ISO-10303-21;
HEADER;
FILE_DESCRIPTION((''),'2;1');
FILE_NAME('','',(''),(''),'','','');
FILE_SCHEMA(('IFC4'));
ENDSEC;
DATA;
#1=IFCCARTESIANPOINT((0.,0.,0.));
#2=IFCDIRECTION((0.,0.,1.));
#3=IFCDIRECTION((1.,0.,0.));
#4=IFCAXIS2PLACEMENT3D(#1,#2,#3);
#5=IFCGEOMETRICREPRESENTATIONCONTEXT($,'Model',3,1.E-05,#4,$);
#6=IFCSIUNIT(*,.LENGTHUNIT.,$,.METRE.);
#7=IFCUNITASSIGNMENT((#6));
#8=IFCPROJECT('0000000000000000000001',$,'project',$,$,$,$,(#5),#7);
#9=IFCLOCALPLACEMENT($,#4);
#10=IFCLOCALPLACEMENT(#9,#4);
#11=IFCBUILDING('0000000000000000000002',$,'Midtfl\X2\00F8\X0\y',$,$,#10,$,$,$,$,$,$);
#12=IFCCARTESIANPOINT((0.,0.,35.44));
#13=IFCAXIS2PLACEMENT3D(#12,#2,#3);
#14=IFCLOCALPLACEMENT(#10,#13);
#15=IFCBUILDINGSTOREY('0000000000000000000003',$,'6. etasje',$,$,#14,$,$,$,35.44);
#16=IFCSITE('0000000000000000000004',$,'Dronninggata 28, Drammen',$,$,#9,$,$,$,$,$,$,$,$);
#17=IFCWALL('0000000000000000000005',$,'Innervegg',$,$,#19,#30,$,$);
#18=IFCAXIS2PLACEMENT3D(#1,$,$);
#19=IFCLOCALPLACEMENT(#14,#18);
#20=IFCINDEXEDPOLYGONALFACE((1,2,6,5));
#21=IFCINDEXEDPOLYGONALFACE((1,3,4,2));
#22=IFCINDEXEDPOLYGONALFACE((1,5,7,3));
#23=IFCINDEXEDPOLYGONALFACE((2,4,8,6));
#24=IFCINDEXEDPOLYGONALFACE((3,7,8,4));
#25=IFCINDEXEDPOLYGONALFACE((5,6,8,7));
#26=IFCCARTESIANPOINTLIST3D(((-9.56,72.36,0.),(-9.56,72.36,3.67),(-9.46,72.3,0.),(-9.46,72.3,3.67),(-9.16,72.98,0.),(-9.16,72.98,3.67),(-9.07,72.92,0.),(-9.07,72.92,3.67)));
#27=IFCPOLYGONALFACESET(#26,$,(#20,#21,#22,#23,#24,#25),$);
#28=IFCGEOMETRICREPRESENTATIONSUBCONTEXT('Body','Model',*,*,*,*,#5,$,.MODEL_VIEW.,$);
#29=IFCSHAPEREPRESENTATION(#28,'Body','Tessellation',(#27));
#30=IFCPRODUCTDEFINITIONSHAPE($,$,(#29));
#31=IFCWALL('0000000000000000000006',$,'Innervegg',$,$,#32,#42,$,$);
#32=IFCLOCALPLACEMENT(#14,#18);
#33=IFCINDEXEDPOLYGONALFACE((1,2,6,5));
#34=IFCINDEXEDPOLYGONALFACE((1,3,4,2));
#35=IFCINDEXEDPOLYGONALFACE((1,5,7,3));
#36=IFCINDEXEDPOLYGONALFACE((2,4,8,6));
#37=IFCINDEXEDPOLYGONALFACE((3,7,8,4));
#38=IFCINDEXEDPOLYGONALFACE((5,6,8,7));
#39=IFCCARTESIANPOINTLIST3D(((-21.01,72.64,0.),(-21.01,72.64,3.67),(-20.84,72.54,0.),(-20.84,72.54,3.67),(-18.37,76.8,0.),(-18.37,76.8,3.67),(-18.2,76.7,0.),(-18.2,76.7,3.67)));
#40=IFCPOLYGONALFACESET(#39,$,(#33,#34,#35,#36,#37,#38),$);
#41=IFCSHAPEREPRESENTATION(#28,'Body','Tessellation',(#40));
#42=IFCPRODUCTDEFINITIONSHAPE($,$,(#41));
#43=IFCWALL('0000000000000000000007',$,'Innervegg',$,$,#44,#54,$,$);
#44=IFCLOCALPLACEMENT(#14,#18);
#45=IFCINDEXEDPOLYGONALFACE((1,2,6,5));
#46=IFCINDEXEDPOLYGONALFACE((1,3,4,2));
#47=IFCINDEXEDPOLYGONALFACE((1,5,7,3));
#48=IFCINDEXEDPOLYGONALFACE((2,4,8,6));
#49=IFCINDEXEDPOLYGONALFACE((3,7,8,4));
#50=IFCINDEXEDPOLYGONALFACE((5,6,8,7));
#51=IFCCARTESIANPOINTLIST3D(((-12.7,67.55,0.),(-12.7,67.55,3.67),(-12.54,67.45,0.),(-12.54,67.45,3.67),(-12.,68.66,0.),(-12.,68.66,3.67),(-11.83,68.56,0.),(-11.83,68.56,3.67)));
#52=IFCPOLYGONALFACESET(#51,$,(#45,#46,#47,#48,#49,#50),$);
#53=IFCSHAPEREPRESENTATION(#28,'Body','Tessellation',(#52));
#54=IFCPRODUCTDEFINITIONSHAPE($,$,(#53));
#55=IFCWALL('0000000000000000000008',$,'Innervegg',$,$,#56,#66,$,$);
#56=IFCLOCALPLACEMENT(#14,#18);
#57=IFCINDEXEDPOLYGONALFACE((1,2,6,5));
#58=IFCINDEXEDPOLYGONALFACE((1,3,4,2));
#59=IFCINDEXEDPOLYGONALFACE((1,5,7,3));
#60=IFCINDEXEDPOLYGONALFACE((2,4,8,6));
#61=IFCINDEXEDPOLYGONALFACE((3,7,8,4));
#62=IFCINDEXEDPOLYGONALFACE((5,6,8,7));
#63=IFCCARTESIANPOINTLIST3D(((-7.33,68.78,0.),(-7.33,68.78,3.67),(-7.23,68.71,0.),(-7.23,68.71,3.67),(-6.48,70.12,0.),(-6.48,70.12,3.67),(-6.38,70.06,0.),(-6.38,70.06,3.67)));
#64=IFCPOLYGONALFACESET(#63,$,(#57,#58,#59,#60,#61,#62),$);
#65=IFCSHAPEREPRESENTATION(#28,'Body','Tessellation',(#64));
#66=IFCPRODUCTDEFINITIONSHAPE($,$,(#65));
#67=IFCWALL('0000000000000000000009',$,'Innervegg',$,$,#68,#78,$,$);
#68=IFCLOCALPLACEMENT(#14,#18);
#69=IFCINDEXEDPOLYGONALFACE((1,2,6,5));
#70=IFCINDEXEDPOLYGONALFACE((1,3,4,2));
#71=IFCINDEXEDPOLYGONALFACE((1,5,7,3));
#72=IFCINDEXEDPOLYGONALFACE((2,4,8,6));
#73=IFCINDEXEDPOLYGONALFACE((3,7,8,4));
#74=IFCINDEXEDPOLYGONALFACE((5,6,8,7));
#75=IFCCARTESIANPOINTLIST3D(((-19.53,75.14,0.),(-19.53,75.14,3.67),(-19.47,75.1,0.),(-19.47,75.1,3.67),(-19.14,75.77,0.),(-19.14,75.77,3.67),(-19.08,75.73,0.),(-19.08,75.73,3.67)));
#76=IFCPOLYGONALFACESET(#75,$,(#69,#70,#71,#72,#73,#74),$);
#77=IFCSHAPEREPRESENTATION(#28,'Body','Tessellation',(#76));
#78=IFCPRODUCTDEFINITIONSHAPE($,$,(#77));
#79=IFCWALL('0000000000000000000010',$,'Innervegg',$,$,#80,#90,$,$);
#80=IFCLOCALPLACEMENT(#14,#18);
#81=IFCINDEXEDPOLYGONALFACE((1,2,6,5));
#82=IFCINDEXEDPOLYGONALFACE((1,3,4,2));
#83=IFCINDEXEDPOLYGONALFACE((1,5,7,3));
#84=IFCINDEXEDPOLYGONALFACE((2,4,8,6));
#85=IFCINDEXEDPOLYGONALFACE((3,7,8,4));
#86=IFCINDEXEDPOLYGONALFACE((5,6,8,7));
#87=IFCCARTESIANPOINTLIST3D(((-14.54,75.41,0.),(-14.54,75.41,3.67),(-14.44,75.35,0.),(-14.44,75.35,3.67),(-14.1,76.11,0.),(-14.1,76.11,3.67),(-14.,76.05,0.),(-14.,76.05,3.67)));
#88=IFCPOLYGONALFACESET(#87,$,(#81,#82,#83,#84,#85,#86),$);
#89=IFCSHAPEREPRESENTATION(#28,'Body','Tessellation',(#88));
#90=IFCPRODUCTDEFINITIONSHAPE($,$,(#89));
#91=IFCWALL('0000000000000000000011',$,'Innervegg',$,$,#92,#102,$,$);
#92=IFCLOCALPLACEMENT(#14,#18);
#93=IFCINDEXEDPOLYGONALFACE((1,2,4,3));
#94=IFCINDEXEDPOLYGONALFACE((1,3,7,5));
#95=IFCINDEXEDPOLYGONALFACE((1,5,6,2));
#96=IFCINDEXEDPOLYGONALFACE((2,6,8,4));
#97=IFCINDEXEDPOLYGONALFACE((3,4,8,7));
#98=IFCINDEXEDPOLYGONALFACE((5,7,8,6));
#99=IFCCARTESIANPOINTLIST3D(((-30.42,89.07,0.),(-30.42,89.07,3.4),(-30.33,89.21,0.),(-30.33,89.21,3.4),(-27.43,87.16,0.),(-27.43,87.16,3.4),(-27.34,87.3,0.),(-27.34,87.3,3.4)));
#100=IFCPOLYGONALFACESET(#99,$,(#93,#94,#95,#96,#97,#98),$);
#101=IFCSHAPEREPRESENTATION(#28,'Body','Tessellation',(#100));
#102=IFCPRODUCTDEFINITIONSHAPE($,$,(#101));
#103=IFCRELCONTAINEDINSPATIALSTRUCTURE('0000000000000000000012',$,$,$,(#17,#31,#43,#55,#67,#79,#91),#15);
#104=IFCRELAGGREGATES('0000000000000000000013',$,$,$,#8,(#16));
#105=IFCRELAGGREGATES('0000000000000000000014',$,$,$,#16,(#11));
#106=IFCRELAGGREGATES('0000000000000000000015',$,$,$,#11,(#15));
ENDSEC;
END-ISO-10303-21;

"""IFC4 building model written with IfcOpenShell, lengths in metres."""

from ifc_helpers import new_model, si_unit, frame, origin_with_axes, place, context, subcontext, project, spatial, polyline, outline, extrude, element, save


model = new_model("IFC4")

# Units and contexts
model_context = context("Model", 3, precision=1e-05, world=origin_with_axes())
body_context = subcontext(model_context, "Body", "Model", "MODEL_VIEW")
ifc_project = project(units=[si_unit("LENGTHUNIT", "METRE")], contexts=[model_context])

# Site, building, storey
site_placement = place(None, origin_with_axes())
site = spatial("IfcSite", under=ifc_project, at=site_placement, Name="Dronninggata 28, Drammen")
building_placement = place(site_placement, origin_with_axes())
building = spatial("IfcBuilding", under=site, at=building_placement, Name="Midtfløy")
storey_placement = place(building_placement, frame((0.0, 0.0, 35.44), z_axis=(0.0, 0.0, 1.0), x_axis=(1.0, 0.0, 0.0)))
storey = spatial("IfcBuildingStorey", under=building, at=storey_placement, Name="6. etasje", Elevation=35.44)

# Walls
wall_1_placement = place(storey_placement, frame((0.0, 0.0, -35.44), z_axis=(0.0, 0.0, 1.0), x_axis=(1.0, 0.0, 0.0)))
element("IfcWall", 1, at=wall_1_placement, inside=storey, Name="Innervegg", context=body_context, shape_type="SweptSolid", body=[
    extrude(outline(polyline([(-9.16, 72.98), (-9.07, 72.92), (-9.46, 72.3), (-9.56, 72.36), (-9.16, 72.98)])), frame((0.0, 0.0, 35.44)), (0.0, 0.0, 1.0), 3.67),
])
wall_2_placement = place(storey_placement, frame((0.0, 0.0, -35.44), z_axis=(0.0, 0.0, 1.0), x_axis=(1.0, 0.0, 0.0)))
element("IfcWall", 2, at=wall_2_placement, inside=storey, Name="Innervegg", context=body_context, shape_type="SweptSolid", body=[
    extrude(outline(polyline([(-18.37, 76.8), (-18.2, 76.7), (-20.84, 72.54), (-21.01, 72.64), (-18.37, 76.8)])), frame((0.0, 0.0, 35.44)), (0.0, 0.0, 1.0), 3.67),
])
wall_3_placement = place(storey_placement, frame((0.0, 0.0, -35.44), z_axis=(0.0, 0.0, 1.0), x_axis=(1.0, 0.0, 0.0)))
element("IfcWall", 3, at=wall_3_placement, inside=storey, Name="Innervegg", context=body_context, shape_type="SweptSolid", body=[
    extrude(outline(polyline([(-12.0, 68.66), (-11.83, 68.56), (-12.54, 67.45), (-12.7, 67.55), (-12.0, 68.66)])), frame((0.0, 0.0, 35.44)), (0.0, 0.0, 1.0), 3.67),
])
wall_4_placement = place(storey_placement, frame((0.0, 0.0, -35.44), z_axis=(0.0, 0.0, 1.0), x_axis=(1.0, 0.0, 0.0)))
element("IfcWall", 4, at=wall_4_placement, inside=storey, Name="Innervegg", context=body_context, shape_type="SweptSolid", body=[
    extrude(outline(polyline([(-6.48, 70.12), (-6.38, 70.06), (-7.23, 68.71), (-7.33, 68.78), (-6.48, 70.12)])), frame((0.0, 0.0, 35.44)), (0.0, 0.0, 1.0), 3.67),
])
wall_5_placement = place(storey_placement, frame((0.0, 0.0, -35.44), z_axis=(0.0, 0.0, 1.0), x_axis=(1.0, 0.0, 0.0)))
element("IfcWall", 5, at=wall_5_placement, inside=storey, Name="Innervegg", context=body_context, shape_type="SweptSolid", body=[
    extrude(outline(polyline([(-19.14, 75.77), (-19.08, 75.73), (-19.47, 75.1), (-19.53, 75.14), (-19.14, 75.77)])), frame((0.0, 0.0, 35.44)), (0.0, 0.0, 1.0), 3.67),
])
wall_6_placement = place(storey_placement, frame((0.0, 0.0, -35.44), z_axis=(0.0, 0.0, 1.0), x_axis=(1.0, 0.0, 0.0)))
element("IfcWall", 6, at=wall_6_placement, inside=storey, Name="Innervegg", context=body_context, shape_type="SweptSolid", body=[
    extrude(outline(polyline([(-14.1, 76.11), (-14.0, 76.05), (-14.44, 75.35), (-14.54, 75.41), (-14.1, 76.11)])), frame((0.0, 0.0, 35.44)), (0.0, 0.0, 1.0), 3.67),
])
wall_7_placement = place(storey_placement, frame((0.0, 0.0, -35.44), z_axis=(0.0, 0.0, 1.0), x_axis=(1.0, 0.0, 0.0)))
element("IfcWall", 7, at=wall_7_placement, inside=storey, Name="Innervegg", context=body_context, shape_type="SweptSolid", body=[
    extrude(outline(polyline([(-30.33, 89.21), (-27.34, 87.3), (-27.43, 87.16), (-30.42, 89.07), (-30.33, 89.21)])), frame((0.0, 0.0, 35.44)), (0.0, 0.0, 1.0), 3.4),
])

save(model, "model.ifc")
